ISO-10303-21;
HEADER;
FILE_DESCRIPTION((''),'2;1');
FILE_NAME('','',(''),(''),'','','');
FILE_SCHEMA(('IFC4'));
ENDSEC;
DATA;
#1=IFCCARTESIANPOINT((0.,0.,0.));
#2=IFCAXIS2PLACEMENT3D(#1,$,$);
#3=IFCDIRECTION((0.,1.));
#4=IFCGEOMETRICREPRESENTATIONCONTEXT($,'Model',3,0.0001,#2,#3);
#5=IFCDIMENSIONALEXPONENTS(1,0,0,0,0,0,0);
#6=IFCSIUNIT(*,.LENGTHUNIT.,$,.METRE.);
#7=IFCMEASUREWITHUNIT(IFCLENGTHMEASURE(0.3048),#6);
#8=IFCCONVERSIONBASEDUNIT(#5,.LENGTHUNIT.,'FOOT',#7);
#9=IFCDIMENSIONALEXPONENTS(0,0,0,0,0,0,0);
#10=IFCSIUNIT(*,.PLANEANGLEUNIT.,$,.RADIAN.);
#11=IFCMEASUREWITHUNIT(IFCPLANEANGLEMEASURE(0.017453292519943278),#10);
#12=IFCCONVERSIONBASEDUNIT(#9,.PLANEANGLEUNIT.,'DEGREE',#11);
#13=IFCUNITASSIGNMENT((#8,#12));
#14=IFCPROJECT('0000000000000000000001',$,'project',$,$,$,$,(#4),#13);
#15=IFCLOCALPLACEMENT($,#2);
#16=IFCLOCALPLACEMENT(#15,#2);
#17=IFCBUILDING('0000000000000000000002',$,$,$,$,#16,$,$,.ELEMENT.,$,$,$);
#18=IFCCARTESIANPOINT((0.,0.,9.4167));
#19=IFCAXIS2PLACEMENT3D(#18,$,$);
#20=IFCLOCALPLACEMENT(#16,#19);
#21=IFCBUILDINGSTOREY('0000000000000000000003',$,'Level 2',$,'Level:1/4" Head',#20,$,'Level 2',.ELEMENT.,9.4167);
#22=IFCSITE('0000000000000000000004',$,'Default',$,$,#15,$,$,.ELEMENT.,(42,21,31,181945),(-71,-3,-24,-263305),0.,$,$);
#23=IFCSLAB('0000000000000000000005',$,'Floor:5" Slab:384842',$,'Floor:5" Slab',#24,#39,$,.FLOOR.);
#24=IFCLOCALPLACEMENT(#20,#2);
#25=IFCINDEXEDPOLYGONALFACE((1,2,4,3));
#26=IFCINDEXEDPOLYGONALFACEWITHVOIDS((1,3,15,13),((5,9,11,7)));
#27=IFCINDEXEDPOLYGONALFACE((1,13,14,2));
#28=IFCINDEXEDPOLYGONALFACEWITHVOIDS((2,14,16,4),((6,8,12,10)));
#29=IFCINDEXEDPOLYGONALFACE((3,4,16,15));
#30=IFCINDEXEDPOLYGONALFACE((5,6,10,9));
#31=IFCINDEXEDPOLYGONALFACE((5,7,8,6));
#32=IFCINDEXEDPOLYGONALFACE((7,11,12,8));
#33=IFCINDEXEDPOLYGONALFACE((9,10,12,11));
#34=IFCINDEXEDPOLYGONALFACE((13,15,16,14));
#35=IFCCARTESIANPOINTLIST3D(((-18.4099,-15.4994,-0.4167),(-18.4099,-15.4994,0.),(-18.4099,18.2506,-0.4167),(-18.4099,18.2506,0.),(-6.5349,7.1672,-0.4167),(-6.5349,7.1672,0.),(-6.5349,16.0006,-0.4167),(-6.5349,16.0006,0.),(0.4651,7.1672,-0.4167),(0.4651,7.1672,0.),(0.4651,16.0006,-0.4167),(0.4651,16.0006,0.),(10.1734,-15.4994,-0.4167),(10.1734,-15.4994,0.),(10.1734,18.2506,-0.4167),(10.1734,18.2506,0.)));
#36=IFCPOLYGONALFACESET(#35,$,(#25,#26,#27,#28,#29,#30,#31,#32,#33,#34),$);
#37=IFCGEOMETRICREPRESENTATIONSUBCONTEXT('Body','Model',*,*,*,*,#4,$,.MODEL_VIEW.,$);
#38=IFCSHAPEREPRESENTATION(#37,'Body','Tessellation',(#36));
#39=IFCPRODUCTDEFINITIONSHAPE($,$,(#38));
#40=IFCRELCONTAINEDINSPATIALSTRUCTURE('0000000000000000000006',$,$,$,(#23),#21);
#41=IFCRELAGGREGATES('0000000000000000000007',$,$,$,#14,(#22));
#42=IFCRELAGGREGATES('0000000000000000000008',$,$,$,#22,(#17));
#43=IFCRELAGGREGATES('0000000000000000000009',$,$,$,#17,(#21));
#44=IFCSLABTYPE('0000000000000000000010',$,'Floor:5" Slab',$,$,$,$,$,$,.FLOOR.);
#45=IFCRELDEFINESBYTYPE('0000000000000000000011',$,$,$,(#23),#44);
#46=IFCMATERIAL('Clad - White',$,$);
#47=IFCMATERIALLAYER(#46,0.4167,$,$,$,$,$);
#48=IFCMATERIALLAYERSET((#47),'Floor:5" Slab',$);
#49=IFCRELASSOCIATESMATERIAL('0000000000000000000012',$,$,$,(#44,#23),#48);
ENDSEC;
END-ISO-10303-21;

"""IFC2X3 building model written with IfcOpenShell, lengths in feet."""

from ifc_helpers import new_model, entity, si_unit, converted_unit, direction, frame, frame_2d, origin, origin_2d_with_axis, place, context, subcontext, project, spatial, rectangle, extrude, material, layer, layer_set, layer_usage, type_object, element, save


model = new_model("IFC2X3")

# Units and contexts
model_context = context("Model", 3, precision=0.0001, world=origin(), true_north=direction((0.0, 1.0)))
body_context = subcontext(model_context, "Body", "Model", "MODEL_VIEW")
ifc_project = project(units=[converted_unit("LENGTHUNIT", "FOOT", entity("IfcLengthMeasure", 0.3048), si_unit("LENGTHUNIT", "METRE"), dimensions=[1, 0, 0, 0, 0, 0, 0]), converted_unit("PLANEANGLEUNIT", "DEGREE", entity("IfcPlaneAngleMeasure", 0.017453292519943278), si_unit("PLANEANGLEUNIT", "RADIAN"), dimensions=[0, 0, 0, 0, 0, 0, 0])], contexts=[model_context])

# Site, building, storey
site_placement = place(None, origin())
site = spatial("IfcSite", under=ifc_project, at=site_placement, Name="Default", CompositionType="ELEMENT", RefLatitude=(42, 21, 31, 181945), RefLongitude=(-71, -3, -24, -263305), RefElevation=0.0)
building_placement = place(site_placement, origin())
building = spatial("IfcBuilding", under=site, at=building_placement, CompositionType="ELEMENT")
storey_placement = place(building_placement, frame((0.0, 0.0, 9.4167)))
storey = spatial("IfcBuildingStorey", under=building, at=storey_placement, Name="Level 2", ObjectType="Level:1/4\" Head", LongName="Level 2", CompositionType="ELEMENT", Elevation=9.4167)

# Slab, opening
ifc_material = material(Name="Clad - White")
ifc_layer = layer(ifc_material, 0.4167)
ifc_layer_set = layer_set([ifc_layer], Name="Floor:5\" Slab")
ifc_layer_usage = layer_usage(ifc_layer_set, "AXIS3", "POSITIVE", 0.0)
slab_type = type_object("IfcSlabType", Name="Floor:5\" Slab", PredefinedType="FLOOR", material=ifc_layer_set)
slab_placement = place(storey_placement, frame((-18.4099, -15.4994, -0.4167)))
slab = element("IfcSlab", 1, at=slab_placement, inside=storey, type_object=slab_type, material=ifc_layer_usage, Name="Floor:5\" Slab:384842", ObjectType="Floor:5\" Slab", PredefinedType="FLOOR", context=body_context, shape_type="SweptSolid", body=[
    extrude(rectangle(XDim=33.75, YDim=28.5833, at=frame_2d((0.0, 0.0), x_axis=(0.0, -1.0))), frame((14.2917, 16.875, 0.4167), z_axis=(0.0, 0.0, -1.0), x_axis=(-1.0, 0.0, 0.0)), (0.0, 0.0, 1.0), 0.4167),
])
opening_placement = place(slab_placement, origin())
element("IfcOpeningElement", 2, at=opening_placement, cuts=slab, ObjectType="Opening", context=body_context, shape_type="SweptSolid", body=[
    extrude(rectangle(XDim=8.8333, YDim=7.0, at=origin_2d_with_axis()), frame((15.375, 27.0833, 0.4167), z_axis=(0.0, 0.0, -1.0), x_axis=(0.0, -1.0, 0.0)), (0.0, 0.0, 1.0), 0.4167),
])

save(model, "model.ifc")
